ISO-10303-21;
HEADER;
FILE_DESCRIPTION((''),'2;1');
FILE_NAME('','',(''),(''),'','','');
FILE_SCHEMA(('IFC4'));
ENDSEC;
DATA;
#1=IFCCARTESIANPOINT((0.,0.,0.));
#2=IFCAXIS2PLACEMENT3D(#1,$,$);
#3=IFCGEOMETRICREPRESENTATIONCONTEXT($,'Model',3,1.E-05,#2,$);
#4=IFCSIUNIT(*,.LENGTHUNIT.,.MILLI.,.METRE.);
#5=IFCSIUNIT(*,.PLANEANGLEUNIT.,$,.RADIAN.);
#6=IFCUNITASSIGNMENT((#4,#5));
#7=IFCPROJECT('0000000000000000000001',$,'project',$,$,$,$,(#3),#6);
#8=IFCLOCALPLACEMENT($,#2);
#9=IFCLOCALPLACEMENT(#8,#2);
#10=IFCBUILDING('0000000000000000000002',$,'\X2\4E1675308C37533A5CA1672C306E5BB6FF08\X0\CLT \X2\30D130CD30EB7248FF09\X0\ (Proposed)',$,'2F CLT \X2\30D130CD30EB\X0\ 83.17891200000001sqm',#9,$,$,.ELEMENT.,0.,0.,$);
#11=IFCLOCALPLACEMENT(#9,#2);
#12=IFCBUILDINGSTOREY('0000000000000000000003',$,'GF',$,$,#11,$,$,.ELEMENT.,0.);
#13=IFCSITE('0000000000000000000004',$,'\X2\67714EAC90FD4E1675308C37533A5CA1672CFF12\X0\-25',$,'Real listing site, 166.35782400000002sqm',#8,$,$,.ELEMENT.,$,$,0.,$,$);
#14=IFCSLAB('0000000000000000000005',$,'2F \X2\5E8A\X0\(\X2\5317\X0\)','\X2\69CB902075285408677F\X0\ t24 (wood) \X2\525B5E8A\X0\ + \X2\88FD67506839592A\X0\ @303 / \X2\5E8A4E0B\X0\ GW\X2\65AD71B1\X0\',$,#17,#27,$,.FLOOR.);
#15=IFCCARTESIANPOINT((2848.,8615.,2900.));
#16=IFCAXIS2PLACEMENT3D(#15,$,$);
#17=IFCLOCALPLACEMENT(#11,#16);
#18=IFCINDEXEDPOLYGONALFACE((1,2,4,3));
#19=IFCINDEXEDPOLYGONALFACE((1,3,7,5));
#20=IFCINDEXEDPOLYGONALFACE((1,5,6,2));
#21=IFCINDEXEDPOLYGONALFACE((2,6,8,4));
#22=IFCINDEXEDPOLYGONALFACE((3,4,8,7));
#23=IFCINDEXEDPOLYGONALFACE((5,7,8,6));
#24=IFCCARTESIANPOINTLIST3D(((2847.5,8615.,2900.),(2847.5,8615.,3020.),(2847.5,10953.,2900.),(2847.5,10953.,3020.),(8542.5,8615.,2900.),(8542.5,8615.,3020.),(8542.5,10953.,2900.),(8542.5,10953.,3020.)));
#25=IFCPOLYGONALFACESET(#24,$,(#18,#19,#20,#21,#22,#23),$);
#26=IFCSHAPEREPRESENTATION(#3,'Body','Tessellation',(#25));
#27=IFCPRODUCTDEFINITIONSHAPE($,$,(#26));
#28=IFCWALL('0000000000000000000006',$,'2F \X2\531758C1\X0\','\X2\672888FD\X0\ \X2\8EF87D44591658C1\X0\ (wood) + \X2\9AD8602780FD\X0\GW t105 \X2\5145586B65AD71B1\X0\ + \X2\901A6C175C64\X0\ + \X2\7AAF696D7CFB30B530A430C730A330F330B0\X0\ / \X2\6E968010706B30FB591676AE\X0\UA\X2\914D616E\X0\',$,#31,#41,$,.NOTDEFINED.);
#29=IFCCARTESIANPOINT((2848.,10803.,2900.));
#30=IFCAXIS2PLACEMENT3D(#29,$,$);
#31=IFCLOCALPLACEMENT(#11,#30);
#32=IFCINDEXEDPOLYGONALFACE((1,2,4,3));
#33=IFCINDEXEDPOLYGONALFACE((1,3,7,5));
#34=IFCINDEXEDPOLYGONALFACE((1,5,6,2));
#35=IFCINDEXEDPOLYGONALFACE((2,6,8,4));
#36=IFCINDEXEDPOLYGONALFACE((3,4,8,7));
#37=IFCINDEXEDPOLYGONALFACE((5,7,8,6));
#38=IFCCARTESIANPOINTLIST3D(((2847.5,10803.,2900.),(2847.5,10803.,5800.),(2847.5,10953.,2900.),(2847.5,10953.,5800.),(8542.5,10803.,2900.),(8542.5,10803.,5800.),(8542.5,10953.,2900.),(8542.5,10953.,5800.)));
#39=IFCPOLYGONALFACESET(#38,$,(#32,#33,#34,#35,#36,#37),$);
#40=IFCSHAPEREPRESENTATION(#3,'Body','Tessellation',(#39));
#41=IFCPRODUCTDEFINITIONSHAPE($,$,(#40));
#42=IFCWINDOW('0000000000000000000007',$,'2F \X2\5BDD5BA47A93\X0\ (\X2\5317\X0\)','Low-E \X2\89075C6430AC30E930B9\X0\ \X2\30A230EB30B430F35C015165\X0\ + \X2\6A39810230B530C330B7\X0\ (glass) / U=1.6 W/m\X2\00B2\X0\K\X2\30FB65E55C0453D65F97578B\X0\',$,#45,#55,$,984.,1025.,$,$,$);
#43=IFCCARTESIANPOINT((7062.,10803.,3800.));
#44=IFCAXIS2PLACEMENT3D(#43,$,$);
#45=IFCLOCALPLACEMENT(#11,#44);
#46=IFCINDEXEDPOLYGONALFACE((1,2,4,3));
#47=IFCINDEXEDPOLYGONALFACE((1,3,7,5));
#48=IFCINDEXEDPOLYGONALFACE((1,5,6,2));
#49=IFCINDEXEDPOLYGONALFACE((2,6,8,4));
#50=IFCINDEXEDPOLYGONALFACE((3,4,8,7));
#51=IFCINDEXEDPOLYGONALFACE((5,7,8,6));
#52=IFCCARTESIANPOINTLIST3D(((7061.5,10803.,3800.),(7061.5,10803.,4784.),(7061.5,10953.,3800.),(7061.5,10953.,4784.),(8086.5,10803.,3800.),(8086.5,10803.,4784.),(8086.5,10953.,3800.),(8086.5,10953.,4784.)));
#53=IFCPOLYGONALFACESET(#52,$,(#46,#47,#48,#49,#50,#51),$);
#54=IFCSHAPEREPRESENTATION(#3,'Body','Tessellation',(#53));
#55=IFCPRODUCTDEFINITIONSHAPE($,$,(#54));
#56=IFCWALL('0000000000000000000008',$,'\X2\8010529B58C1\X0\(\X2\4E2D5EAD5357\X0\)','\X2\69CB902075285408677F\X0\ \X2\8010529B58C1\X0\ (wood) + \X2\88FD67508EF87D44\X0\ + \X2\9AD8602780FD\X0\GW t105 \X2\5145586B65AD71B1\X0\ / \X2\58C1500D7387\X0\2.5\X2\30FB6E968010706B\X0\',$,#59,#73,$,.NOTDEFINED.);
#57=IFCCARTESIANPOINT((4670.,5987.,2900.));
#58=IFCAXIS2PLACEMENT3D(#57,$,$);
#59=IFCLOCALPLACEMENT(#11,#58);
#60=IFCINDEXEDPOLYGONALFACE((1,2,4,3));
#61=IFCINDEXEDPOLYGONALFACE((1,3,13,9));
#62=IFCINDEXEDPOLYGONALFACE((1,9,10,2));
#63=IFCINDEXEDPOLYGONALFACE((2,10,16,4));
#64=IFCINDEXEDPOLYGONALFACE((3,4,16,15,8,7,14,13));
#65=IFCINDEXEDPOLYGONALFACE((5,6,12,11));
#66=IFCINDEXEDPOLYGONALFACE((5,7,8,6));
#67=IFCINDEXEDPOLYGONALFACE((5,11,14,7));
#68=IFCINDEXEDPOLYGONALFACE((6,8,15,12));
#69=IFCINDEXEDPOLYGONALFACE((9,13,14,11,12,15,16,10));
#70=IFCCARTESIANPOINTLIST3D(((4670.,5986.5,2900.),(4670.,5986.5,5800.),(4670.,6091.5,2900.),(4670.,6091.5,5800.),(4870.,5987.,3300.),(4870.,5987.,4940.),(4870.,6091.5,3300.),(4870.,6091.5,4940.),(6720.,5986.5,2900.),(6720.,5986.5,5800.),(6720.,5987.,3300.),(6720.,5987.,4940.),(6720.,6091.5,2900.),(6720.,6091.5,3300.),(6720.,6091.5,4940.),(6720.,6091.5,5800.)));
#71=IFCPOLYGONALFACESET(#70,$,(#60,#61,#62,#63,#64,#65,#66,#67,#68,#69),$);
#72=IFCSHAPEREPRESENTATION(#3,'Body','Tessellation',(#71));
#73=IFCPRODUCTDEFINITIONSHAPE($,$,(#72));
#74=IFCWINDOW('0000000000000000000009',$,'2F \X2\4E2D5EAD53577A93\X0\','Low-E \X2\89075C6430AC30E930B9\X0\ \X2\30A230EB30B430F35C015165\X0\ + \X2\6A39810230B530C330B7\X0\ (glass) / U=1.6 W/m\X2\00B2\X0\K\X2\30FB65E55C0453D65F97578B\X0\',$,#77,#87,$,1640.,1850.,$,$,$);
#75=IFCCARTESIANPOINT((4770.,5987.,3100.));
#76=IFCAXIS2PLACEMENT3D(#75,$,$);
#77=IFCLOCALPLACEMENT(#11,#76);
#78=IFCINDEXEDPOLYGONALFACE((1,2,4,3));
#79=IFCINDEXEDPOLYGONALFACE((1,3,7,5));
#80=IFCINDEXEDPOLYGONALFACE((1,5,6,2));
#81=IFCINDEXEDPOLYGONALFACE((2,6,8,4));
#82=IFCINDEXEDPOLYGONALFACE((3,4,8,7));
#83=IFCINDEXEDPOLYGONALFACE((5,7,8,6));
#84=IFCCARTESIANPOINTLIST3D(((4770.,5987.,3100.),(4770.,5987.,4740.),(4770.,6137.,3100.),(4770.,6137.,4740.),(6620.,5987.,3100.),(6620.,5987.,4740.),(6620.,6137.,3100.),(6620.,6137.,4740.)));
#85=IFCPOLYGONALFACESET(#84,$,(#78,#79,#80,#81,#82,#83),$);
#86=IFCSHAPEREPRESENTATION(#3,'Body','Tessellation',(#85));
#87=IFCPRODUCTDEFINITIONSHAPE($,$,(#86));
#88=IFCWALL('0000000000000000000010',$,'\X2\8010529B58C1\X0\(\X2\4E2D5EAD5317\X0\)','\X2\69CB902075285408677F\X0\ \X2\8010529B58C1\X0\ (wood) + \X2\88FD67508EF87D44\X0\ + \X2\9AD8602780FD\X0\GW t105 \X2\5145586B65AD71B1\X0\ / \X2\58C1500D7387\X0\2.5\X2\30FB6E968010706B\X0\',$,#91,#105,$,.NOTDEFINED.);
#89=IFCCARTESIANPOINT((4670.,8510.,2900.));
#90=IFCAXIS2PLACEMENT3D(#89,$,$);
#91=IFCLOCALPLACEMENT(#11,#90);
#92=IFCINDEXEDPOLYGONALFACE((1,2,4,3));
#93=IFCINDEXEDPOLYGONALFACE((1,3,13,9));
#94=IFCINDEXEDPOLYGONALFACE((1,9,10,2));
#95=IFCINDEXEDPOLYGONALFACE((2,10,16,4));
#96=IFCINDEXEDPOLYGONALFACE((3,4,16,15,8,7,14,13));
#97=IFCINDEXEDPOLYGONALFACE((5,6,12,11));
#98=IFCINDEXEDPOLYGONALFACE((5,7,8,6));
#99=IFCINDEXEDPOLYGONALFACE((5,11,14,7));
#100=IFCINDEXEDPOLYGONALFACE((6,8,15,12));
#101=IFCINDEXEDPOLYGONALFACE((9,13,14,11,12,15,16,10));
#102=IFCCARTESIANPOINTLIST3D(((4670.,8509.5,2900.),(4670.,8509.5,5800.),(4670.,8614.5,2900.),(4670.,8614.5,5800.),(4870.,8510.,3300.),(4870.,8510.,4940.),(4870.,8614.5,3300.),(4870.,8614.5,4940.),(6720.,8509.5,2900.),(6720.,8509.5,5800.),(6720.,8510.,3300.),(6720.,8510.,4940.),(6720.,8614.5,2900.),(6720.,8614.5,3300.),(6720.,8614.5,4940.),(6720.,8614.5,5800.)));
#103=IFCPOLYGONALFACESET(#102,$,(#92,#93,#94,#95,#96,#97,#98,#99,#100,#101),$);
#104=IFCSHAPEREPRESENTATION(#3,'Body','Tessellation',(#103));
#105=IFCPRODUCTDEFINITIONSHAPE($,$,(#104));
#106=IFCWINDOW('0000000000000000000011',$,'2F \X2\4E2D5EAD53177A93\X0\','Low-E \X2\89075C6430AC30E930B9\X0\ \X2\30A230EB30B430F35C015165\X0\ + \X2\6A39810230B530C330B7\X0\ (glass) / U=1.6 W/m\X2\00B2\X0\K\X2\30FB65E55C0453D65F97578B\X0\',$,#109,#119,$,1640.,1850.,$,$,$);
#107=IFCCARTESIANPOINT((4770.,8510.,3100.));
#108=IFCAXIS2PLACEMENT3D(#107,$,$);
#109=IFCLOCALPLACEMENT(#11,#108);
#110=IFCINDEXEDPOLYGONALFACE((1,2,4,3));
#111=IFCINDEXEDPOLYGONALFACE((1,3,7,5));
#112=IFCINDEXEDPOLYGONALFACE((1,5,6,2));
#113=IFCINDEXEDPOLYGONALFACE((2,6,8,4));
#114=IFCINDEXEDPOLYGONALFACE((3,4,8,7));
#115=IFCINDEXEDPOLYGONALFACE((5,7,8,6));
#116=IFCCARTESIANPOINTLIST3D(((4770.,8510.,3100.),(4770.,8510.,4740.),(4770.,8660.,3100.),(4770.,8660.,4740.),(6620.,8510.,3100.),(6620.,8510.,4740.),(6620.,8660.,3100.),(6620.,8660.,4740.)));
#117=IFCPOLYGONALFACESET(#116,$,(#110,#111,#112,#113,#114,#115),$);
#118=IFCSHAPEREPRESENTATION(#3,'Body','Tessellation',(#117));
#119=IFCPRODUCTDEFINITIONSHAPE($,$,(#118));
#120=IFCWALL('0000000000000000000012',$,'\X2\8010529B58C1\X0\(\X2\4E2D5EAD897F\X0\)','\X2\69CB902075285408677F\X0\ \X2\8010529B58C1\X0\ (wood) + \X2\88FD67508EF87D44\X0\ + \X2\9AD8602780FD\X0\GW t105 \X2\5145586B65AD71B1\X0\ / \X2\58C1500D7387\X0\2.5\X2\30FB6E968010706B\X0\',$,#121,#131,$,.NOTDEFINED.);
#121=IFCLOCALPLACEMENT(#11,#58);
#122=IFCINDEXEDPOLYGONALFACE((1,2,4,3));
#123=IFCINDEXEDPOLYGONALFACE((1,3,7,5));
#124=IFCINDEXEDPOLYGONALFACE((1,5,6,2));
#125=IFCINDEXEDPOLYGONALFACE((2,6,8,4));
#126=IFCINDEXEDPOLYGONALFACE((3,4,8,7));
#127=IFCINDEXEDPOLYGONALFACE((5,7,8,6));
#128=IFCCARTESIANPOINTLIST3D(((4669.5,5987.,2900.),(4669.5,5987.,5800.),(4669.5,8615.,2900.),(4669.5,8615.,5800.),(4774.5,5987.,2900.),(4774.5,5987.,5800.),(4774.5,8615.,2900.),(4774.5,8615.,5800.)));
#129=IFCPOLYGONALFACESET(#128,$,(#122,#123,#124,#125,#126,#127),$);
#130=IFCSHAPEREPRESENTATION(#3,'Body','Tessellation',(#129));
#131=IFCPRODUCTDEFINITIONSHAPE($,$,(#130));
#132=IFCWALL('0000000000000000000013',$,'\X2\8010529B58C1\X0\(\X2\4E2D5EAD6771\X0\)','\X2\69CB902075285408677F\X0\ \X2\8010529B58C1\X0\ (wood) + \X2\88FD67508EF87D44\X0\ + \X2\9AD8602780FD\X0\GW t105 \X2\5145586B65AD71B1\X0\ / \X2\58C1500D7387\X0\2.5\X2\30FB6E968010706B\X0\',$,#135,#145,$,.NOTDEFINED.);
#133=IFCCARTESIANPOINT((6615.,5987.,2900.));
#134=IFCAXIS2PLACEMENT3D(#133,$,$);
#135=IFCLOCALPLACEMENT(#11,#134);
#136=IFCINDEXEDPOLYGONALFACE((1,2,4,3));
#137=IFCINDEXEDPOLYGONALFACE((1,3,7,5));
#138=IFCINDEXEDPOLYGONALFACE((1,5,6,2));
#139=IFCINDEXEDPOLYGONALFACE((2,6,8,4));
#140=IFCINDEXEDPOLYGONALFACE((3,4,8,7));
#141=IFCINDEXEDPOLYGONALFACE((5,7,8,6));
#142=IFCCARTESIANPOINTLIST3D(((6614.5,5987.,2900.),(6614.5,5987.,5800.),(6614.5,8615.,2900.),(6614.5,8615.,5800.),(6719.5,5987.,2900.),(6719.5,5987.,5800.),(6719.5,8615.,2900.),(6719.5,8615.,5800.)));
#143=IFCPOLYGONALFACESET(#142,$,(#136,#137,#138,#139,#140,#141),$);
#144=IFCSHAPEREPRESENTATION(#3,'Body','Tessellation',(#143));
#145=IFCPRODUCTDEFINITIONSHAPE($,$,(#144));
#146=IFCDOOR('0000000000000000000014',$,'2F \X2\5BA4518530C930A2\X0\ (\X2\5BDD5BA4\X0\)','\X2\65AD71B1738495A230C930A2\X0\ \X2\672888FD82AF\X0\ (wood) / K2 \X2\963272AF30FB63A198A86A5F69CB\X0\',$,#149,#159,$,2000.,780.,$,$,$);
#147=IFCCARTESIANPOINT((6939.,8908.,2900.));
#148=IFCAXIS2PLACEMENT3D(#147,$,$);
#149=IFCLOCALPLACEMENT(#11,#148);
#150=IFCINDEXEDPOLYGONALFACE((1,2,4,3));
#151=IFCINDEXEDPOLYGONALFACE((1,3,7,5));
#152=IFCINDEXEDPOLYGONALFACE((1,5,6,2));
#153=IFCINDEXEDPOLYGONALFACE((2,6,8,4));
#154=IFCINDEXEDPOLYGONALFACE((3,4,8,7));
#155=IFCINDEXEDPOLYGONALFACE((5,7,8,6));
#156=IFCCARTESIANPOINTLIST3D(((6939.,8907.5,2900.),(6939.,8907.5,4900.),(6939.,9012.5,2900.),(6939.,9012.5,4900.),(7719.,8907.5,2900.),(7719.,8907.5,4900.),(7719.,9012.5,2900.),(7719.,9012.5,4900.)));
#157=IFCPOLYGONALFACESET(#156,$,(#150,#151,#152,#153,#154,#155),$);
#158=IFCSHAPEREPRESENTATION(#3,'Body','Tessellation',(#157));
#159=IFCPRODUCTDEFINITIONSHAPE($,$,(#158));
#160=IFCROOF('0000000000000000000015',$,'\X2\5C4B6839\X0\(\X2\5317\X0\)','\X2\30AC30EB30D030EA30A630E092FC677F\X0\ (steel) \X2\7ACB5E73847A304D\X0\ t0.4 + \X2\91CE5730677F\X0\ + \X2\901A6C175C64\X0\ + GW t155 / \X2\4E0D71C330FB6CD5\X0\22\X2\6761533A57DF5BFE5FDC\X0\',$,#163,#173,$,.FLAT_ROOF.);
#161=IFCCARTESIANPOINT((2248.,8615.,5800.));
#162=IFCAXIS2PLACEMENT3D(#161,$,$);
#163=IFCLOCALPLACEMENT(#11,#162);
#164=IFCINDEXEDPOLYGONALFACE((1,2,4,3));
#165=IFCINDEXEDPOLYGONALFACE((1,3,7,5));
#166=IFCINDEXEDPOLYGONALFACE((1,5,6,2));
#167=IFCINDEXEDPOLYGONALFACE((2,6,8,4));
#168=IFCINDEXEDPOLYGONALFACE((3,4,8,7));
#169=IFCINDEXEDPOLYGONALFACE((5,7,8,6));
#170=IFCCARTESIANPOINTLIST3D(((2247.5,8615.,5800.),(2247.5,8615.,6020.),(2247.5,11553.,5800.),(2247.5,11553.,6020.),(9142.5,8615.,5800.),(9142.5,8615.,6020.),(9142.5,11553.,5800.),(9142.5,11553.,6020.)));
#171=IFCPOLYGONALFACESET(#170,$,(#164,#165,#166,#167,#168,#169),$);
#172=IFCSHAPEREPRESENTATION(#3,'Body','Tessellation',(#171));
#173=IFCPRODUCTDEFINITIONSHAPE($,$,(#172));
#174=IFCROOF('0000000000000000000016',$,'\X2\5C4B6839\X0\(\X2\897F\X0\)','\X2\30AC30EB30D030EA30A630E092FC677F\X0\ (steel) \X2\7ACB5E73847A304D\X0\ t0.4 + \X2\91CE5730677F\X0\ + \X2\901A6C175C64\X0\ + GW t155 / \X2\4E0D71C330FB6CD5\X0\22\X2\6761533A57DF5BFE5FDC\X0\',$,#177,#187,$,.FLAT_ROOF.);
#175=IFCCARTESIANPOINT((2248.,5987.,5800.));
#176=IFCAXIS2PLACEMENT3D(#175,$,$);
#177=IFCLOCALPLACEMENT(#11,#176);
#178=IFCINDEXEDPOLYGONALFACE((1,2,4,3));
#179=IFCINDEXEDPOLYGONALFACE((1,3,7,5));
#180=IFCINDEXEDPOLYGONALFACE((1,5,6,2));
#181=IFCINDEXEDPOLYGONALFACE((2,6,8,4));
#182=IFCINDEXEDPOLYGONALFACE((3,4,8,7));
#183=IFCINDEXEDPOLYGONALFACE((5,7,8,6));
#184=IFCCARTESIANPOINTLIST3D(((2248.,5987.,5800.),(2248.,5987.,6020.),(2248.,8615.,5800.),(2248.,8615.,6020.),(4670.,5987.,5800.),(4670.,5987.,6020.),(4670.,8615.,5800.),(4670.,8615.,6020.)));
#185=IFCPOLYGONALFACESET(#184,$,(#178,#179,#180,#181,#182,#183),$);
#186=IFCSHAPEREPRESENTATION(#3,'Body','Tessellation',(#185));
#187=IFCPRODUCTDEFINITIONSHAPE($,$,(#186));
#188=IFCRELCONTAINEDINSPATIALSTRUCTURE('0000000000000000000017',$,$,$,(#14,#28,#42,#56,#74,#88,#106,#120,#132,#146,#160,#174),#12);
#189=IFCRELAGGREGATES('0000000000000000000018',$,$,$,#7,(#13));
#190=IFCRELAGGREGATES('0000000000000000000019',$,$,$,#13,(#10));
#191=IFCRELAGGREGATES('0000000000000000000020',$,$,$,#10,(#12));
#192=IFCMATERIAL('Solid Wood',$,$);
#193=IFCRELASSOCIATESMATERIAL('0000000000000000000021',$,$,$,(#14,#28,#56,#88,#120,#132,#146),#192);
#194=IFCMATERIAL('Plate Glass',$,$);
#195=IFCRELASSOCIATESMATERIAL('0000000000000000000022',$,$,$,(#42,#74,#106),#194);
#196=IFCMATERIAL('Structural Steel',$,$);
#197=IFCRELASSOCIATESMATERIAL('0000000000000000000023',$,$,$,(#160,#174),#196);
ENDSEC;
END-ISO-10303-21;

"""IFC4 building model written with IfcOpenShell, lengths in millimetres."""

from ifc_helpers import new_model, si_unit, frame, frame_2d, origin, place, context, project, spatial, rectangle, extrude, material, element, fill, save


model = new_model("IFC4")

# Units and contexts
model_context = context("Model", 3, precision=1e-05, world=origin())
ifc_project = project(units=[si_unit("LENGTHUNIT", "METRE", prefix="MILLI"), si_unit("PLANEANGLEUNIT", "RADIAN")], contexts=[model_context])

# Site, building, storey
site_placement = place(None, origin())
site = spatial("IfcSite", under=ifc_project, at=site_placement, Name="東京都世田谷区岡本２-25", ObjectType="Real listing site, 166.35782400000002sqm", CompositionType="ELEMENT", RefElevation=0.0)
building_placement = place(site_placement, origin())
building = spatial("IfcBuilding", under=site, at=building_placement, Name="世田谷区岡本の家（CLT パネル版） (Proposed)", ObjectType="2F CLT パネル 83.17891200000001sqm", CompositionType="ELEMENT", ElevationOfRefHeight=0.0, ElevationOfTerrain=0.0)
storey_placement = place(building_placement, origin())
storey = spatial("IfcBuildingStorey", under=building, at=storey_placement, Name="GF", CompositionType="ELEMENT", Elevation=0.0)

# Slab
ifc_material_1 = material(Name="Solid Wood")
slab_placement = place(storey_placement, frame((2848.0, 8615.0, 2900.0)))
element("IfcSlab", 1, at=slab_placement, inside=storey, material=ifc_material_1, Name="2F 床(北)", Description="構造用合板 t24 (wood) 剛床 + 製材根太 @303 / 床下 GW断熱", PredefinedType="FLOOR", context=model_context, shape_type="SweptSolid", body=[
    extrude(rectangle(XDim=5695.0, YDim=2338.0, at=frame_2d((2847.0, 1169.0))), frame((2848.0, 8615.0, 2900.0)), (0.0, 0.0, 1.0), 120.0),
])

# Walls, openings, windows
wall_1_placement = place(storey_placement, frame((2848.0, 10803.0, 2900.0)))
wall_1 = element("IfcWall", 2, at=wall_1_placement, inside=storey, material=ifc_material_1, Name="2F 北壁", Description="木製 軸組外壁 (wood) + 高性能GW t105 充填断熱 + 通気層 + 窯業系サイディング / 準耐火・外皮UA配慮", PredefinedType="NOTDEFINED", context=model_context, shape_type="SweptSolid", body=[
    extrude(rectangle(XDim=5695.0, YDim=150.0, at=frame_2d((2847.0, 75.0))), frame((2848.0, 10803.0, 2900.0)), (0.0, 0.0, 1.0), 2900.0),
])
opening_1_placement = place(storey_placement, frame((7062.0, 10803.0, 3800.0)))
opening_1 = element("IfcOpeningElement", 3, at=opening_1_placement, cuts=wall_1, PredefinedType="NOTDEFINED", context=model_context, shape_type="SweptSolid", body=[
    extrude(rectangle(XDim=1025.0, YDim=150.0, at=frame_2d((512.0, 75.0))), frame((7062.0, 10803.0, 3800.0)), (0.0, 0.0, 1.0), 984.0),
])
ifc_material_2 = material(Name="Plate Glass")
window_1_placement = place(storey_placement, frame((7062.0, 10803.0, 3800.0)))
window_1 = element("IfcWindow", 4, at=window_1_placement, inside=storey, material=ifc_material_2, Name="2F 寝室窓 (北)", Description="Low-E 複層ガラス アルゴン封入 + 樹脂サッシ (glass) / U=1.6 W/m²K・日射取得型", OverallHeight=984.0, OverallWidth=1025.0, context=model_context, shape_type="SweptSolid", body=[
    extrude(rectangle(XDim=1025.0, YDim=150.0, at=frame_2d((512.0, 75.0))), frame((7062.0, 10803.0, 3800.0)), (0.0, 0.0, 1.0), 984.0),
])
fill(opening_1, window_1)
wall_2_placement = place(storey_placement, frame((4670.0, 5987.0, 2900.0)))
wall_2 = element("IfcWall", 5, at=wall_2_placement, inside=storey, material=ifc_material_1, Name="耐力壁(中庭南)", Description="構造用合板 耐力壁 (wood) + 製材軸組 + 高性能GW t105 充填断熱 / 壁倍率2.5・準耐火", PredefinedType="NOTDEFINED", context=model_context, shape_type="SweptSolid", body=[
    extrude(rectangle(XDim=2050.0, YDim=105.0, at=frame_2d((1025.0, 52.0))), frame((4670.0, 5987.0, 2900.0)), (0.0, 0.0, 1.0), 2900.0),
])
opening_2_placement = place(storey_placement, frame((4770.0, 5987.0, 3100.0)))
opening_2 = element("IfcOpeningElement", 6, at=opening_2_placement, cuts=wall_2, PredefinedType="NOTDEFINED", context=model_context, shape_type="SweptSolid", body=[
    extrude(rectangle(XDim=1850.0, YDim=150.0, at=frame_2d((925.0, 75.0))), frame((4770.0, 5987.0, 3100.0)), (0.0, 0.0, 1.0), 1640.0),
])
window_2_placement = place(storey_placement, frame((4770.0, 5987.0, 3100.0)))
window_2 = element("IfcWindow", 7, at=window_2_placement, inside=storey, material=ifc_material_2, Name="2F 中庭南窓", Description="Low-E 複層ガラス アルゴン封入 + 樹脂サッシ (glass) / U=1.6 W/m²K・日射取得型", OverallHeight=1640.0, OverallWidth=1850.0, context=model_context, shape_type="SweptSolid", body=[
    extrude(rectangle(XDim=1850.0, YDim=150.0, at=frame_2d((925.0, 75.0))), frame((4770.0, 5987.0, 3100.0)), (0.0, 0.0, 1.0), 1640.0),
])
fill(opening_2, window_2)
wall_3_placement = place(storey_placement, frame((4670.0, 8510.0, 2900.0)))
wall_3 = element("IfcWall", 8, at=wall_3_placement, inside=storey, material=ifc_material_1, Name="耐力壁(中庭北)", Description="構造用合板 耐力壁 (wood) + 製材軸組 + 高性能GW t105 充填断熱 / 壁倍率2.5・準耐火", PredefinedType="NOTDEFINED", context=model_context, shape_type="SweptSolid", body=[
    extrude(rectangle(XDim=2050.0, YDim=105.0, at=frame_2d((1025.0, 52.0))), frame((4670.0, 8510.0, 2900.0)), (0.0, 0.0, 1.0), 2900.0),
])
opening_3_placement = place(storey_placement, frame((4770.0, 8510.0, 3100.0)))
opening_3 = element("IfcOpeningElement", 9, at=opening_3_placement, cuts=wall_3, PredefinedType="NOTDEFINED", context=model_context, shape_type="SweptSolid", body=[
    extrude(rectangle(XDim=1850.0, YDim=150.0, at=frame_2d((925.0, 75.0))), frame((4770.0, 8510.0, 3100.0)), (0.0, 0.0, 1.0), 1640.0),
])
window_3_placement = place(storey_placement, frame((4770.0, 8510.0, 3100.0)))
window_3 = element("IfcWindow", 10, at=window_3_placement, inside=storey, material=ifc_material_2, Name="2F 中庭北窓", Description="Low-E 複層ガラス アルゴン封入 + 樹脂サッシ (glass) / U=1.6 W/m²K・日射取得型", OverallHeight=1640.0, OverallWidth=1850.0, context=model_context, shape_type="SweptSolid", body=[
    extrude(rectangle(XDim=1850.0, YDim=150.0, at=frame_2d((925.0, 75.0))), frame((4770.0, 8510.0, 3100.0)), (0.0, 0.0, 1.0), 1640.0),
])
fill(opening_3, window_3)

# Walls
wall_4_placement = place(storey_placement, frame((4670.0, 5987.0, 2900.0)))
element("IfcWall", 11, at=wall_4_placement, inside=storey, material=ifc_material_1, Name="耐力壁(中庭西)", Description="構造用合板 耐力壁 (wood) + 製材軸組 + 高性能GW t105 充填断熱 / 壁倍率2.5・準耐火", PredefinedType="NOTDEFINED", context=model_context, shape_type="SweptSolid", body=[
    extrude(rectangle(XDim=105.0, YDim=2628.0, at=frame_2d((52.0, 1314.0))), frame((4670.0, 5987.0, 2900.0)), (0.0, 0.0, 1.0), 2900.0),
])
wall_5_placement = place(storey_placement, frame((6615.0, 5987.0, 2900.0)))
element("IfcWall", 12, at=wall_5_placement, inside=storey, material=ifc_material_1, Name="耐力壁(中庭東)", Description="構造用合板 耐力壁 (wood) + 製材軸組 + 高性能GW t105 充填断熱 / 壁倍率2.5・準耐火", PredefinedType="NOTDEFINED", context=model_context, shape_type="SweptSolid", body=[
    extrude(rectangle(XDim=105.0, YDim=2628.0, at=frame_2d((52.0, 1314.0))), frame((6615.0, 5987.0, 2900.0)), (0.0, 0.0, 1.0), 2900.0),
])

# Door
door_placement = place(storey_placement, frame((6939.0, 8908.0, 2900.0)))
element("IfcDoor", 13, at=door_placement, inside=storey, material=ifc_material_1, Name="2F 室内ドア (寝室)", Description="断熱玄関ドア 木製芯 (wood) / K2 防犯・採風機構", OverallHeight=2000.0, OverallWidth=780.0, context=model_context, shape_type="SweptSolid", body=[
    extrude(rectangle(XDim=780.0, YDim=105.0, at=frame_2d((390.0, 52.0))), frame((6939.0, 8908.0, 2900.0)), (0.0, 0.0, 1.0), 2000.0),
])

# Roofs
ifc_material_3 = material(Name="Structural Steel")
for number, where, name in (
    (14, (2248.0, 8615.0, 5800.0), "屋根(北)"),
):
    element("IfcRoof", number, at=place(storey_placement, frame(where)), inside=storey, material=ifc_material_3, Name=name, Description="ガルバリウム鋼板 (steel) 立平葺き t0.4 + 野地板 + 通気層 + GW t155 / 不燃・法22条区域対応", PredefinedType="FLAT_ROOF", context=model_context, shape_type="SweptSolid", body=[
        extrude(rectangle(XDim=6895.0, YDim=2938.0, at=frame_2d((3447.0, 1469.0))), frame((2248.0, 8615.0, 5800.0)), (0.0, 0.0, 1.0), 220.0),
    ])
roof_1_placement = place(storey_placement, frame((2248.0, 5987.0, 5800.0)))
element("IfcRoof", 15, at=roof_1_placement, inside=storey, material=ifc_material_3, Name="屋根(西)", Description="ガルバリウム鋼板 (steel) 立平葺き t0.4 + 野地板 + 通気層 + GW t155 / 不燃・法22条区域対応", PredefinedType="FLAT_ROOF", context=model_context, shape_type="SweptSolid", body=[
    extrude(rectangle(XDim=2422.0, YDim=2628.0, at=frame_2d((1211.0, 1314.0))), frame((2248.0, 5987.0, 5800.0)), (0.0, 0.0, 1.0), 220.0),
])

save(model, "model.ifc")
